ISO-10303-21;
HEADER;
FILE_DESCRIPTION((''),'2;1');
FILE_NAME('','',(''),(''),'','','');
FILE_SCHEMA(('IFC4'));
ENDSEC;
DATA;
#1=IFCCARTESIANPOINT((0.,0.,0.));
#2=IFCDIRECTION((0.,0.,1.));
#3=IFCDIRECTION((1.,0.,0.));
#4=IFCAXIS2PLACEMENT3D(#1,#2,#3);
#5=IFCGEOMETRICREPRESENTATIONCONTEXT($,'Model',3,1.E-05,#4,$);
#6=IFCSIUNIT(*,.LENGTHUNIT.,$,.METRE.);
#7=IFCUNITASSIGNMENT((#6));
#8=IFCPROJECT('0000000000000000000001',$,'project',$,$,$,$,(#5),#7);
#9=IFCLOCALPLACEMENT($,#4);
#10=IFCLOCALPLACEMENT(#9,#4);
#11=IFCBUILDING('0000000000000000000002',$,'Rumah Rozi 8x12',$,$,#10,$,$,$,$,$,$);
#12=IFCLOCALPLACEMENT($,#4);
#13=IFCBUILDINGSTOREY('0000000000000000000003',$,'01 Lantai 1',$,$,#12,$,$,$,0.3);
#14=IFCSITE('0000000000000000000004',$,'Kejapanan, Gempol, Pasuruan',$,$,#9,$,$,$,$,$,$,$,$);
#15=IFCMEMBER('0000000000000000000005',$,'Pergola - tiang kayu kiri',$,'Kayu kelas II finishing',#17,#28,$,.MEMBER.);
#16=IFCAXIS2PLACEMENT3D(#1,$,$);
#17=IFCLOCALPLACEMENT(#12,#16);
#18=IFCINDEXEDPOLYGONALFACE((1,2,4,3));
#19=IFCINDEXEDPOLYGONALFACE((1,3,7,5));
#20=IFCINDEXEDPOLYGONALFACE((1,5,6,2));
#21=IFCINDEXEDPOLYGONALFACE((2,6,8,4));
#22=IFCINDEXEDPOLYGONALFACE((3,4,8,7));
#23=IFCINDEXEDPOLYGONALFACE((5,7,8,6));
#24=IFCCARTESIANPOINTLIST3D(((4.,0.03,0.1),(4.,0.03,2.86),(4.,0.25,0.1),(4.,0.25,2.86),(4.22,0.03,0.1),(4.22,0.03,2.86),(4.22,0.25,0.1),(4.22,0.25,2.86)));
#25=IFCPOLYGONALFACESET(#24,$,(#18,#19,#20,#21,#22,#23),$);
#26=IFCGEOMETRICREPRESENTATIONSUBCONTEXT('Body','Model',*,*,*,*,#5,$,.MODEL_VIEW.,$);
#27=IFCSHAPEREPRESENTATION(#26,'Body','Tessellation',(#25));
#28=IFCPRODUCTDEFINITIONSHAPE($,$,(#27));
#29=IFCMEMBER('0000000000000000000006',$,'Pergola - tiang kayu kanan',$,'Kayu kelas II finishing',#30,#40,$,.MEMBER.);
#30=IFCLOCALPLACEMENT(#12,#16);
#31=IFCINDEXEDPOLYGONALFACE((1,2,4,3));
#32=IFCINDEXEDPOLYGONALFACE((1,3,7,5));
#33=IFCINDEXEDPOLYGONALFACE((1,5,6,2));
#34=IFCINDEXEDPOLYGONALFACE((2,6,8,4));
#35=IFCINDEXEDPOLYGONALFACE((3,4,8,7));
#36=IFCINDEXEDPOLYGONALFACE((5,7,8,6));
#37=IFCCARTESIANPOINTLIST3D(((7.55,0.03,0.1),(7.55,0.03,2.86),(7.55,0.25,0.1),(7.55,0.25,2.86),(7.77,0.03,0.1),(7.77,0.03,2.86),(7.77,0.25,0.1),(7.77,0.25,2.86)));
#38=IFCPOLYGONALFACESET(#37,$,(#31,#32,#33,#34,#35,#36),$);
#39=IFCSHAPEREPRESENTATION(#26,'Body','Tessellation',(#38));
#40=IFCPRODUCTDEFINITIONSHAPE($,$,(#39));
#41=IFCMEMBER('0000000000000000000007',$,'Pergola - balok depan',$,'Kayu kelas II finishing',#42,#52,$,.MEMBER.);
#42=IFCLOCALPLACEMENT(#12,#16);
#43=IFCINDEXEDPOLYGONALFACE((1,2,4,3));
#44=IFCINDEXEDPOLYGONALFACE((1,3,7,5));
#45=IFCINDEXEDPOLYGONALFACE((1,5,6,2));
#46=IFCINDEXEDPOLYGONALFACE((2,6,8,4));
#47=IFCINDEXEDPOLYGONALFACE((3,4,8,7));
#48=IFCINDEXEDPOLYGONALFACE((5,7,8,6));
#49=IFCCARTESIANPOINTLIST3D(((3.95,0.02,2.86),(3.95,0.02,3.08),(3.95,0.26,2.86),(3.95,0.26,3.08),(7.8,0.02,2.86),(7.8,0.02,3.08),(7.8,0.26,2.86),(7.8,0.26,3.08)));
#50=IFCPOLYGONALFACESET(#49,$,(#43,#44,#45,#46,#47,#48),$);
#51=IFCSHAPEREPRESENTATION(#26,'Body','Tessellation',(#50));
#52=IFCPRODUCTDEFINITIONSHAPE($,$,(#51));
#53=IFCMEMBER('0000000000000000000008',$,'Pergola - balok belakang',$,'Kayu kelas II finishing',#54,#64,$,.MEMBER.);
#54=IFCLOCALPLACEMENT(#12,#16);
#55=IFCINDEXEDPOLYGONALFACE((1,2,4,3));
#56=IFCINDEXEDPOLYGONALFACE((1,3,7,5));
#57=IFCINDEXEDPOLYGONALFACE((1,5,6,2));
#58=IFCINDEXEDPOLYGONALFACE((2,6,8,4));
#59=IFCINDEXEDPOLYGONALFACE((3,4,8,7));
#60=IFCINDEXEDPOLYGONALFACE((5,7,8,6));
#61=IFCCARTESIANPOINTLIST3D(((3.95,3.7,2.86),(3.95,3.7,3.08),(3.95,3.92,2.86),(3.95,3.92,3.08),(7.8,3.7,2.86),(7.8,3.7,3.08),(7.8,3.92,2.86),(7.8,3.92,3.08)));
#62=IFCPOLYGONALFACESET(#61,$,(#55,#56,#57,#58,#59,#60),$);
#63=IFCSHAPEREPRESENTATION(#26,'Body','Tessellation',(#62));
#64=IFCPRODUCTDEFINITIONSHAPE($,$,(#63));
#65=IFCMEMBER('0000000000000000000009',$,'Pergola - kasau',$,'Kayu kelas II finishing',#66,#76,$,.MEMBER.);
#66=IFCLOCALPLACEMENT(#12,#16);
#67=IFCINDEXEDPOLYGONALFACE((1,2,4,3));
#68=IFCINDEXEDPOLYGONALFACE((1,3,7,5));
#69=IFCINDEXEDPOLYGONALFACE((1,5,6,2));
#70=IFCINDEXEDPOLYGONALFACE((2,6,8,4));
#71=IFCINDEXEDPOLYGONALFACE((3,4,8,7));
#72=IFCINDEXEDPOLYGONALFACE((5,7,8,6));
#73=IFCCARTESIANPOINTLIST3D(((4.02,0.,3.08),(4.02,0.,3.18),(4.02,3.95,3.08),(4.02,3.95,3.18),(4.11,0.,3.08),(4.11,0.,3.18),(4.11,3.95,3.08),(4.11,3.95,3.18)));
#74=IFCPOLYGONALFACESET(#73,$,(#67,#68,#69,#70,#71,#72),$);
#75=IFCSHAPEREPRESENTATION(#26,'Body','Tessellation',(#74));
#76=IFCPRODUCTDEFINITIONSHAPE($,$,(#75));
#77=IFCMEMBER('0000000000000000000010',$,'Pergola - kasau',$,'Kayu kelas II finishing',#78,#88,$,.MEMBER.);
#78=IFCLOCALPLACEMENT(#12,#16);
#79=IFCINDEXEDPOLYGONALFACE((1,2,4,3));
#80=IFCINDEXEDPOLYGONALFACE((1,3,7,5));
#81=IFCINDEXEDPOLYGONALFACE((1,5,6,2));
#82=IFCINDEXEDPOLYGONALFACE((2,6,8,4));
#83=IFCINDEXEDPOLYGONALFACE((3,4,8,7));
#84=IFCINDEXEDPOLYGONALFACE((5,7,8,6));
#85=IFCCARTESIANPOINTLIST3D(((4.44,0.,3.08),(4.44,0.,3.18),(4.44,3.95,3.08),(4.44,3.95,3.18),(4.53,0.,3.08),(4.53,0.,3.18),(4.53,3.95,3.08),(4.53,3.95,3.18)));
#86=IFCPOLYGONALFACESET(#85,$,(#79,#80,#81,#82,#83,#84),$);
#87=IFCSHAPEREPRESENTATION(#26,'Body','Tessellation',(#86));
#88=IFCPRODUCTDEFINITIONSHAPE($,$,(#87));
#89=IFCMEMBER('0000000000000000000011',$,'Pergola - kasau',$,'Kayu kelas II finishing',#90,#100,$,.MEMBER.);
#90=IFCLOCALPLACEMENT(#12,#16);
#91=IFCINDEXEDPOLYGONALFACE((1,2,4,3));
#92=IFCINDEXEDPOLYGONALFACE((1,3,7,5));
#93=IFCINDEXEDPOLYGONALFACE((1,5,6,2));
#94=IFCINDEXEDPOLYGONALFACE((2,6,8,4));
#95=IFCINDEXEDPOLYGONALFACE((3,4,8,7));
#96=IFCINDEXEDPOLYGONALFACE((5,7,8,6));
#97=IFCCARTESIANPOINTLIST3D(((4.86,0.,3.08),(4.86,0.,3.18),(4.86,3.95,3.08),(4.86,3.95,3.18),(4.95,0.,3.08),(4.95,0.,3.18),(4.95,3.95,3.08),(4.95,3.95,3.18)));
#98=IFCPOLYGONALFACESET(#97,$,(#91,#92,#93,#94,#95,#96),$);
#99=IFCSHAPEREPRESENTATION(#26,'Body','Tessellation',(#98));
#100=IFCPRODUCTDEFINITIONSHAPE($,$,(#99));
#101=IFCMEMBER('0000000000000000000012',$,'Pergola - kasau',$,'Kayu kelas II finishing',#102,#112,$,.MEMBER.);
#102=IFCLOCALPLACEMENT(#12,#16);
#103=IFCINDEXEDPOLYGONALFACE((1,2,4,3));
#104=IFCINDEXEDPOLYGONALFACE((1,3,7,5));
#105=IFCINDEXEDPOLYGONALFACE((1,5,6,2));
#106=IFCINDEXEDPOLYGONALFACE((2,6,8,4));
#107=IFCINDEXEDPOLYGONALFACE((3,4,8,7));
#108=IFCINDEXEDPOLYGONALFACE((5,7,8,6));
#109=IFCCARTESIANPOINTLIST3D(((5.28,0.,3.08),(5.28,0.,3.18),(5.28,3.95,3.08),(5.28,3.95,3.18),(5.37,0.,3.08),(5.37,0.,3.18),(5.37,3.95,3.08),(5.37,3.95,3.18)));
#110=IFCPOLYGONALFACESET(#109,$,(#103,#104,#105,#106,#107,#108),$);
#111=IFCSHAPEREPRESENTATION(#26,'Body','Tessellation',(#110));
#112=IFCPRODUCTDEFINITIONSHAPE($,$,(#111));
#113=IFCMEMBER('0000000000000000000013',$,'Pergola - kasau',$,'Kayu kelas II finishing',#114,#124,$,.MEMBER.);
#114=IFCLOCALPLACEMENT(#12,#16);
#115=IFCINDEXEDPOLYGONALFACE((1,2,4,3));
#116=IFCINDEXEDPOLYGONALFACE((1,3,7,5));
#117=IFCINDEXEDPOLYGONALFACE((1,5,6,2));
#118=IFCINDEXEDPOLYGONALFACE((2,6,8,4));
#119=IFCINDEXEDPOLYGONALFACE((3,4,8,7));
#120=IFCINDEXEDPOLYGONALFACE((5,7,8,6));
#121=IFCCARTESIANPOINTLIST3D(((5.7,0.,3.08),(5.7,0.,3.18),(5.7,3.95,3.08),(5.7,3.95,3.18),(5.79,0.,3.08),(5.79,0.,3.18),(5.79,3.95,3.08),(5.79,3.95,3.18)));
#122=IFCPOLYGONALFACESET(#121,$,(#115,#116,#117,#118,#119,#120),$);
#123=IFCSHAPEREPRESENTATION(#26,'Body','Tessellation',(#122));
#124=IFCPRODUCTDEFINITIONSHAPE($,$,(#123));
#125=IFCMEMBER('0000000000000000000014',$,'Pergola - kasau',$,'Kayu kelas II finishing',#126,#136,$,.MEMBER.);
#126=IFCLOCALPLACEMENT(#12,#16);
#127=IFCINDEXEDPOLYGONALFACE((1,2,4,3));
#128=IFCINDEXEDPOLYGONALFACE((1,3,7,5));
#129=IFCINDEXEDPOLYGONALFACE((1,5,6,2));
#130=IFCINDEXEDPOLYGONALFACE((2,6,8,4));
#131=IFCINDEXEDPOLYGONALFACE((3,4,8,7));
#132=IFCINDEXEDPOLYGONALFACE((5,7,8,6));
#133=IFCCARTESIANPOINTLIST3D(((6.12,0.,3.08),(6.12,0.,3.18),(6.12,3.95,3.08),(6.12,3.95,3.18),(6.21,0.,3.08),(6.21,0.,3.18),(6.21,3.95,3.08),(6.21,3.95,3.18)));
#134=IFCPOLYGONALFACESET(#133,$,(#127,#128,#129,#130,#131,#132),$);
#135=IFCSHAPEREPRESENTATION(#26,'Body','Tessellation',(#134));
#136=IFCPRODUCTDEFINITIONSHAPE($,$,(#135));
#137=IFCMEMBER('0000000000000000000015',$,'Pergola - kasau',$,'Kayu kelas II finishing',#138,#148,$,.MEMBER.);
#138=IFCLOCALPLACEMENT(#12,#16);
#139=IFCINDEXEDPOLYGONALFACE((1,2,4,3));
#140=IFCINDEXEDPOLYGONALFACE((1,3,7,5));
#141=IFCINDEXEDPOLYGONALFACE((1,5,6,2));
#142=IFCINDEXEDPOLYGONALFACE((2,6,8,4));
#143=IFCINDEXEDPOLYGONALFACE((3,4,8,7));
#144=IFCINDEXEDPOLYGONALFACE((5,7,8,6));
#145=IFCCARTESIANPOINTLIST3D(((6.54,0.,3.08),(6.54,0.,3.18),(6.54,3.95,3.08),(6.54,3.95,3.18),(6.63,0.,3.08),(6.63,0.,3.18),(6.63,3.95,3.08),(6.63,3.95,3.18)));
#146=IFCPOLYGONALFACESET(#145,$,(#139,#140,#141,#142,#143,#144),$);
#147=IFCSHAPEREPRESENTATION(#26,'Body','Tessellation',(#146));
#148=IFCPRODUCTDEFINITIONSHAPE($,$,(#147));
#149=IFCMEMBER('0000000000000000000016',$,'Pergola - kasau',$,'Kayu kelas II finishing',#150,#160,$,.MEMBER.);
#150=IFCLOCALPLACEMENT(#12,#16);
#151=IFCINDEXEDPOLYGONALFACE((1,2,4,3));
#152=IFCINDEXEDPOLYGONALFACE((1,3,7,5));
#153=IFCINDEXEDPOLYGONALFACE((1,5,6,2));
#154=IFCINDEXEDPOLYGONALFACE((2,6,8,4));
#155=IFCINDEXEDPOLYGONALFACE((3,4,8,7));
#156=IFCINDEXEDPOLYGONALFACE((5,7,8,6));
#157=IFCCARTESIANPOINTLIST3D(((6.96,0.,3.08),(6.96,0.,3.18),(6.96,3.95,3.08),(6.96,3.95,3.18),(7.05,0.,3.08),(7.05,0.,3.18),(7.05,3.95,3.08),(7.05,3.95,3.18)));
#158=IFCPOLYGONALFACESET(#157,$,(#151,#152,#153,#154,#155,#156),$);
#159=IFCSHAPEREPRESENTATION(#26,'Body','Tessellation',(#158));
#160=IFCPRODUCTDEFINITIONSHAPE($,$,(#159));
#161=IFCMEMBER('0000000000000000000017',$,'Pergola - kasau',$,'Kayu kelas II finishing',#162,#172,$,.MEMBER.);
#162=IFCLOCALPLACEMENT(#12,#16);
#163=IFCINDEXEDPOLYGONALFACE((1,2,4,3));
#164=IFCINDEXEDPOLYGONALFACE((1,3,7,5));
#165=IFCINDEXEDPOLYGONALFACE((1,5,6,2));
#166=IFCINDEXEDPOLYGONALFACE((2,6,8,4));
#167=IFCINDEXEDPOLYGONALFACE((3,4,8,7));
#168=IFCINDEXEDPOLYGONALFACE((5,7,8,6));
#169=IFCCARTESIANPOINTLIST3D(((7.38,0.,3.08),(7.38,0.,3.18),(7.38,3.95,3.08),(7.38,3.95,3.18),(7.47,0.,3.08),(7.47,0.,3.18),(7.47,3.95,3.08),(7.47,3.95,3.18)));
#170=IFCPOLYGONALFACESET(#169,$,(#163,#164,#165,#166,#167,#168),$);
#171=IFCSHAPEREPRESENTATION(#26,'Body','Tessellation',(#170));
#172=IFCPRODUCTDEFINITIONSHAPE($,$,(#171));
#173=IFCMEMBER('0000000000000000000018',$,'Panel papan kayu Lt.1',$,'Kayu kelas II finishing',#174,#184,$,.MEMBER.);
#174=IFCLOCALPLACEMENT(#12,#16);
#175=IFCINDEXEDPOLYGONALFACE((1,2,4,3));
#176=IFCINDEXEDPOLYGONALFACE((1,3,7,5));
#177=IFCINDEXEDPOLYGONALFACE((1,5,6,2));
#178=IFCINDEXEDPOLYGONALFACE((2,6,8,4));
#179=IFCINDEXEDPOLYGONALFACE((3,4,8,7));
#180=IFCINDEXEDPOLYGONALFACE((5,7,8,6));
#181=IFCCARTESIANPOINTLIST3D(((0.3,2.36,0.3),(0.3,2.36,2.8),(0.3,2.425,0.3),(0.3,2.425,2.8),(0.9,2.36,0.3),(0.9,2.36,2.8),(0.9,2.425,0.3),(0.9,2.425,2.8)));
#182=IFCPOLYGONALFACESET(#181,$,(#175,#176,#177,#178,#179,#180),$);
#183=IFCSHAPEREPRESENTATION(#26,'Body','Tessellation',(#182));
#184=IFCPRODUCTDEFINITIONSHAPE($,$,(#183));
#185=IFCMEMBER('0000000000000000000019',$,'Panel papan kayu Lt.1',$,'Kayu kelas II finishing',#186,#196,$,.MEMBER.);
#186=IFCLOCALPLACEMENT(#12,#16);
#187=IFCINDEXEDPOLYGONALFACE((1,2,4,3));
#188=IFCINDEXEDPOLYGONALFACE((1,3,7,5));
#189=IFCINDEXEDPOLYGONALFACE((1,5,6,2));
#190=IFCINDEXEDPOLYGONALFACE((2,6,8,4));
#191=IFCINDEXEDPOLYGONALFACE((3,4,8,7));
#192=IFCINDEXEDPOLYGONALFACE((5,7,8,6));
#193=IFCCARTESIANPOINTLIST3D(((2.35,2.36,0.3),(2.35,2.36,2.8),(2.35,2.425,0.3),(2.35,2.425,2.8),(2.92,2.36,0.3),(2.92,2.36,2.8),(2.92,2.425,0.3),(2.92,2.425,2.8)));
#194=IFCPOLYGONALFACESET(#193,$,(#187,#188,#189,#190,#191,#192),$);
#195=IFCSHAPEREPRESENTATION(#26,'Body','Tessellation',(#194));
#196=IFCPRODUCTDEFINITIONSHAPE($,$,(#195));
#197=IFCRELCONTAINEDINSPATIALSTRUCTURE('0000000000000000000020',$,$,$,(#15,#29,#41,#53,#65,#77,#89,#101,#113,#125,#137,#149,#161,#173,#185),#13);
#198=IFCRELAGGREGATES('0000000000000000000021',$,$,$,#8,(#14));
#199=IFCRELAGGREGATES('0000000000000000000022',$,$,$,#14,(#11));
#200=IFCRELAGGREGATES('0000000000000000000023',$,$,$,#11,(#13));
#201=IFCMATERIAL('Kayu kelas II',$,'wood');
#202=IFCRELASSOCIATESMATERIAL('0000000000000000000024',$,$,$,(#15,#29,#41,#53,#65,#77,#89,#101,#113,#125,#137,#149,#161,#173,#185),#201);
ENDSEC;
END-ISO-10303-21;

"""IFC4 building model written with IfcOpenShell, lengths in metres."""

from ifc_helpers import new_model, si_unit, frame, origin_with_axes, place, context, subcontext, project, spatial, line, indexed_curve, outline, extrude, material, element, save


model = new_model("IFC4")

# Units and contexts
model_context = context("Model", 3, precision=1e-05, world=origin_with_axes())
body_context = subcontext(model_context, "Body", "Model", "MODEL_VIEW")
ifc_project = project(units=[si_unit("LENGTHUNIT", "METRE")], contexts=[model_context])

# Site, building, storey
site_placement = place(None, origin_with_axes())
site = spatial("IfcSite", under=ifc_project, at=site_placement, Name="Kejapanan, Gempol, Pasuruan")
building_placement = place(site_placement, origin_with_axes())
building = spatial("IfcBuilding", under=site, at=building_placement, Name="Rumah Rozi 8x12")
storey_placement = place(None, origin_with_axes())
storey = spatial("IfcBuildingStorey", under=building, at=storey_placement, Name="01 Lantai 1", Elevation=0.3)

# Members
ifc_material_1 = material(Name="Kayu kelas II", Category="wood")
member_1_placement = place(storey_placement, origin_with_axes())
element("IfcMember", 1, at=member_1_placement, inside=storey, material=ifc_material_1, Name="Pergola - tiang kayu kiri", ObjectType="Kayu kelas II finishing", PredefinedType="MEMBER", context=body_context, shape_type="SweptSolid", body=[
    extrude(outline(indexed_curve([(4.0, 0.03), (4.22, 0.03), (4.22, 0.25), (4.0, 0.25)], segments=[line(1, 2, 3, 4, 1)])), frame((0.0, 0.0, 0.1), z_axis=(0.0, 0.0, 1.0), x_axis=(1.0, 0.0, 0.0)), (0.0, 0.0, 1.0), 2.76),
])
member_2_placement = place(storey_placement, origin_with_axes())
element("IfcMember", 2, at=member_2_placement, inside=storey, material=ifc_material_1, Name="Pergola - tiang kayu kanan", ObjectType="Kayu kelas II finishing", PredefinedType="MEMBER", context=body_context, shape_type="SweptSolid", body=[
    extrude(outline(indexed_curve([(7.55, 0.03), (7.77, 0.03), (7.77, 0.25), (7.55, 0.25)], segments=[line(1, 2, 3, 4, 1)])), frame((0.0, 0.0, 0.1), z_axis=(0.0, 0.0, 1.0), x_axis=(1.0, 0.0, 0.0)), (0.0, 0.0, 1.0), 2.76),
])
member_3_placement = place(storey_placement, origin_with_axes())
element("IfcMember", 3, at=member_3_placement, inside=storey, material=ifc_material_1, Name="Pergola - balok depan", ObjectType="Kayu kelas II finishing", PredefinedType="MEMBER", context=body_context, shape_type="SweptSolid", body=[
    extrude(outline(indexed_curve([(3.95, 0.02), (7.8, 0.02), (7.8, 0.26), (3.95, 0.26)], segments=[line(1, 2, 3, 4, 1)])), frame((0.0, 0.0, 2.86), z_axis=(0.0, 0.0, 1.0), x_axis=(1.0, 0.0, 0.0)), (0.0, 0.0, 1.0), 0.22),
])
member_4_placement = place(storey_placement, origin_with_axes())
element("IfcMember", 4, at=member_4_placement, inside=storey, material=ifc_material_1, Name="Pergola - balok belakang", ObjectType="Kayu kelas II finishing", PredefinedType="MEMBER", context=body_context, shape_type="SweptSolid", body=[
    extrude(outline(indexed_curve([(3.95, 3.7), (7.8, 3.7), (7.8, 3.92), (3.95, 3.92)], segments=[line(1, 2, 3, 4, 1)])), frame((0.0, 0.0, 2.86), z_axis=(0.0, 0.0, 1.0), x_axis=(1.0, 0.0, 0.0)), (0.0, 0.0, 1.0), 0.22),
])
member_5_placement = place(storey_placement, origin_with_axes())
element("IfcMember", 5, at=member_5_placement, inside=storey, material=ifc_material_1, Name="Pergola - kasau", ObjectType="Kayu kelas II finishing", PredefinedType="MEMBER", context=body_context, shape_type="SweptSolid", body=[
    extrude(outline(indexed_curve([(4.02, 0.0), (4.11, 0.0), (4.11, 3.95), (4.02, 3.95)], segments=[line(1, 2, 3, 4, 1)])), frame((0.0, 0.0, 3.08), z_axis=(0.0, 0.0, 1.0), x_axis=(1.0, 0.0, 0.0)), (0.0, 0.0, 1.0), 0.1),
])
member_6_placement = place(storey_placement, origin_with_axes())
element("IfcMember", 6, at=member_6_placement, inside=storey, material=ifc_material_1, Name="Pergola - kasau", ObjectType="Kayu kelas II finishing", PredefinedType="MEMBER", context=body_context, shape_type="SweptSolid", body=[
    extrude(outline(indexed_curve([(4.44, 0.0), (4.53, 0.0), (4.53, 3.95), (4.44, 3.95)], segments=[line(1, 2, 3, 4, 1)])), frame((0.0, 0.0, 3.08), z_axis=(0.0, 0.0, 1.0), x_axis=(1.0, 0.0, 0.0)), (0.0, 0.0, 1.0), 0.1),
])
member_7_placement = place(storey_placement, origin_with_axes())
element("IfcMember", 7, at=member_7_placement, inside=storey, material=ifc_material_1, Name="Pergola - kasau", ObjectType="Kayu kelas II finishing", PredefinedType="MEMBER", context=body_context, shape_type="SweptSolid", body=[
    extrude(outline(indexed_curve([(4.86, 0.0), (4.95, 0.0), (4.95, 3.95), (4.86, 3.95)], segments=[line(1, 2, 3, 4, 1)])), frame((0.0, 0.0, 3.08), z_axis=(0.0, 0.0, 1.0), x_axis=(1.0, 0.0, 0.0)), (0.0, 0.0, 1.0), 0.1),
])
member_8_placement = place(storey_placement, origin_with_axes())
element("IfcMember", 8, at=member_8_placement, inside=storey, material=ifc_material_1, Name="Pergola - kasau", ObjectType="Kayu kelas II finishing", PredefinedType="MEMBER", context=body_context, shape_type="SweptSolid", body=[
    extrude(outline(indexed_curve([(5.28, 0.0), (5.37, 0.0), (5.37, 3.95), (5.28, 3.95)], segments=[line(1, 2, 3, 4, 1)])), frame((0.0, 0.0, 3.08), z_axis=(0.0, 0.0, 1.0), x_axis=(1.0, 0.0, 0.0)), (0.0, 0.0, 1.0), 0.1),
])
member_9_placement = place(storey_placement, origin_with_axes())
element("IfcMember", 9, at=member_9_placement, inside=storey, material=ifc_material_1, Name="Pergola - kasau", ObjectType="Kayu kelas II finishing", PredefinedType="MEMBER", context=body_context, shape_type="SweptSolid", body=[
    extrude(outline(indexed_curve([(5.7, 0.0), (5.79, 0.0), (5.79, 3.95), (5.7, 3.95)], segments=[line(1, 2, 3, 4, 1)])), frame((0.0, 0.0, 3.08), z_axis=(0.0, 0.0, 1.0), x_axis=(1.0, 0.0, 0.0)), (0.0, 0.0, 1.0), 0.1),
])
member_10_placement = place(storey_placement, origin_with_axes())
element("IfcMember", 10, at=member_10_placement, inside=storey, material=ifc_material_1, Name="Pergola - kasau", ObjectType="Kayu kelas II finishing", PredefinedType="MEMBER", context=body_context, shape_type="SweptSolid", body=[
    extrude(outline(indexed_curve([(6.12, 0.0), (6.21, 0.0), (6.21, 3.95), (6.12, 3.95)], segments=[line(1, 2, 3, 4, 1)])), frame((0.0, 0.0, 3.08), z_axis=(0.0, 0.0, 1.0), x_axis=(1.0, 0.0, 0.0)), (0.0, 0.0, 1.0), 0.1),
])
member_11_placement = place(storey_placement, origin_with_axes())
element("IfcMember", 11, at=member_11_placement, inside=storey, material=ifc_material_1, Name="Pergola - kasau", ObjectType="Kayu kelas II finishing", PredefinedType="MEMBER", context=body_context, shape_type="SweptSolid", body=[
    extrude(outline(indexed_curve([(6.54, 0.0), (6.63, 0.0), (6.63, 3.95), (6.54, 3.95)], segments=[line(1, 2, 3, 4, 1)])), frame((0.0, 0.0, 3.08), z_axis=(0.0, 0.0, 1.0), x_axis=(1.0, 0.0, 0.0)), (0.0, 0.0, 1.0), 0.1),
])
member_12_placement = place(storey_placement, origin_with_axes())
element("IfcMember", 12, at=member_12_placement, inside=storey, material=ifc_material_1, Name="Pergola - kasau", ObjectType="Kayu kelas II finishing", PredefinedType="MEMBER", context=body_context, shape_type="SweptSolid", body=[
    extrude(outline(indexed_curve([(6.96, 0.0), (7.05, 0.0), (7.05, 3.95), (6.96, 3.95)], segments=[line(1, 2, 3, 4, 1)])), frame((0.0, 0.0, 3.08), z_axis=(0.0, 0.0, 1.0), x_axis=(1.0, 0.0, 0.0)), (0.0, 0.0, 1.0), 0.1),
])
member_13_placement = place(storey_placement, origin_with_axes())
element("IfcMember", 13, at=member_13_placement, inside=storey, material=ifc_material_1, Name="Pergola - kasau", ObjectType="Kayu kelas II finishing", PredefinedType="MEMBER", context=body_context, shape_type="SweptSolid", body=[
    extrude(outline(indexed_curve([(7.38, 0.0), (7.47, 0.0), (7.47, 3.95), (7.38, 3.95)], segments=[line(1, 2, 3, 4, 1)])), frame((0.0, 0.0, 3.08), z_axis=(0.0, 0.0, 1.0), x_axis=(1.0, 0.0, 0.0)), (0.0, 0.0, 1.0), 0.1),
])
member_14_placement = place(storey_placement, origin_with_axes())
element("IfcMember", 14, at=member_14_placement, inside=storey, material=ifc_material_1, Name="Panel papan kayu Lt.1", ObjectType="Kayu kelas II finishing", PredefinedType="MEMBER", context=body_context, shape_type="SweptSolid", body=[
    extrude(outline(indexed_curve([(0.3, 2.36), (0.9, 2.36), (0.9, 2.425), (0.3, 2.425)], segments=[line(1, 2, 3, 4, 1)])), frame((0.0, 0.0, 0.3), z_axis=(0.0, 0.0, 1.0), x_axis=(1.0, 0.0, 0.0)), (0.0, 0.0, 1.0), 2.5),
])
member_15_placement = place(storey_placement, origin_with_axes())
element("IfcMember", 15, at=member_15_placement, inside=storey, material=ifc_material_1, Name="Panel papan kayu Lt.1", ObjectType="Kayu kelas II finishing", PredefinedType="MEMBER", context=body_context, shape_type="SweptSolid", body=[
    extrude(outline(indexed_curve([(2.35, 2.36), (2.92, 2.36), (2.92, 2.425), (2.35, 2.425)], segments=[line(1, 2, 3, 4, 1)])), frame((0.0, 0.0, 0.3), z_axis=(0.0, 0.0, 1.0), x_axis=(1.0, 0.0, 0.0)), (0.0, 0.0, 1.0), 2.5),
])

save(model, "model.ifc")
